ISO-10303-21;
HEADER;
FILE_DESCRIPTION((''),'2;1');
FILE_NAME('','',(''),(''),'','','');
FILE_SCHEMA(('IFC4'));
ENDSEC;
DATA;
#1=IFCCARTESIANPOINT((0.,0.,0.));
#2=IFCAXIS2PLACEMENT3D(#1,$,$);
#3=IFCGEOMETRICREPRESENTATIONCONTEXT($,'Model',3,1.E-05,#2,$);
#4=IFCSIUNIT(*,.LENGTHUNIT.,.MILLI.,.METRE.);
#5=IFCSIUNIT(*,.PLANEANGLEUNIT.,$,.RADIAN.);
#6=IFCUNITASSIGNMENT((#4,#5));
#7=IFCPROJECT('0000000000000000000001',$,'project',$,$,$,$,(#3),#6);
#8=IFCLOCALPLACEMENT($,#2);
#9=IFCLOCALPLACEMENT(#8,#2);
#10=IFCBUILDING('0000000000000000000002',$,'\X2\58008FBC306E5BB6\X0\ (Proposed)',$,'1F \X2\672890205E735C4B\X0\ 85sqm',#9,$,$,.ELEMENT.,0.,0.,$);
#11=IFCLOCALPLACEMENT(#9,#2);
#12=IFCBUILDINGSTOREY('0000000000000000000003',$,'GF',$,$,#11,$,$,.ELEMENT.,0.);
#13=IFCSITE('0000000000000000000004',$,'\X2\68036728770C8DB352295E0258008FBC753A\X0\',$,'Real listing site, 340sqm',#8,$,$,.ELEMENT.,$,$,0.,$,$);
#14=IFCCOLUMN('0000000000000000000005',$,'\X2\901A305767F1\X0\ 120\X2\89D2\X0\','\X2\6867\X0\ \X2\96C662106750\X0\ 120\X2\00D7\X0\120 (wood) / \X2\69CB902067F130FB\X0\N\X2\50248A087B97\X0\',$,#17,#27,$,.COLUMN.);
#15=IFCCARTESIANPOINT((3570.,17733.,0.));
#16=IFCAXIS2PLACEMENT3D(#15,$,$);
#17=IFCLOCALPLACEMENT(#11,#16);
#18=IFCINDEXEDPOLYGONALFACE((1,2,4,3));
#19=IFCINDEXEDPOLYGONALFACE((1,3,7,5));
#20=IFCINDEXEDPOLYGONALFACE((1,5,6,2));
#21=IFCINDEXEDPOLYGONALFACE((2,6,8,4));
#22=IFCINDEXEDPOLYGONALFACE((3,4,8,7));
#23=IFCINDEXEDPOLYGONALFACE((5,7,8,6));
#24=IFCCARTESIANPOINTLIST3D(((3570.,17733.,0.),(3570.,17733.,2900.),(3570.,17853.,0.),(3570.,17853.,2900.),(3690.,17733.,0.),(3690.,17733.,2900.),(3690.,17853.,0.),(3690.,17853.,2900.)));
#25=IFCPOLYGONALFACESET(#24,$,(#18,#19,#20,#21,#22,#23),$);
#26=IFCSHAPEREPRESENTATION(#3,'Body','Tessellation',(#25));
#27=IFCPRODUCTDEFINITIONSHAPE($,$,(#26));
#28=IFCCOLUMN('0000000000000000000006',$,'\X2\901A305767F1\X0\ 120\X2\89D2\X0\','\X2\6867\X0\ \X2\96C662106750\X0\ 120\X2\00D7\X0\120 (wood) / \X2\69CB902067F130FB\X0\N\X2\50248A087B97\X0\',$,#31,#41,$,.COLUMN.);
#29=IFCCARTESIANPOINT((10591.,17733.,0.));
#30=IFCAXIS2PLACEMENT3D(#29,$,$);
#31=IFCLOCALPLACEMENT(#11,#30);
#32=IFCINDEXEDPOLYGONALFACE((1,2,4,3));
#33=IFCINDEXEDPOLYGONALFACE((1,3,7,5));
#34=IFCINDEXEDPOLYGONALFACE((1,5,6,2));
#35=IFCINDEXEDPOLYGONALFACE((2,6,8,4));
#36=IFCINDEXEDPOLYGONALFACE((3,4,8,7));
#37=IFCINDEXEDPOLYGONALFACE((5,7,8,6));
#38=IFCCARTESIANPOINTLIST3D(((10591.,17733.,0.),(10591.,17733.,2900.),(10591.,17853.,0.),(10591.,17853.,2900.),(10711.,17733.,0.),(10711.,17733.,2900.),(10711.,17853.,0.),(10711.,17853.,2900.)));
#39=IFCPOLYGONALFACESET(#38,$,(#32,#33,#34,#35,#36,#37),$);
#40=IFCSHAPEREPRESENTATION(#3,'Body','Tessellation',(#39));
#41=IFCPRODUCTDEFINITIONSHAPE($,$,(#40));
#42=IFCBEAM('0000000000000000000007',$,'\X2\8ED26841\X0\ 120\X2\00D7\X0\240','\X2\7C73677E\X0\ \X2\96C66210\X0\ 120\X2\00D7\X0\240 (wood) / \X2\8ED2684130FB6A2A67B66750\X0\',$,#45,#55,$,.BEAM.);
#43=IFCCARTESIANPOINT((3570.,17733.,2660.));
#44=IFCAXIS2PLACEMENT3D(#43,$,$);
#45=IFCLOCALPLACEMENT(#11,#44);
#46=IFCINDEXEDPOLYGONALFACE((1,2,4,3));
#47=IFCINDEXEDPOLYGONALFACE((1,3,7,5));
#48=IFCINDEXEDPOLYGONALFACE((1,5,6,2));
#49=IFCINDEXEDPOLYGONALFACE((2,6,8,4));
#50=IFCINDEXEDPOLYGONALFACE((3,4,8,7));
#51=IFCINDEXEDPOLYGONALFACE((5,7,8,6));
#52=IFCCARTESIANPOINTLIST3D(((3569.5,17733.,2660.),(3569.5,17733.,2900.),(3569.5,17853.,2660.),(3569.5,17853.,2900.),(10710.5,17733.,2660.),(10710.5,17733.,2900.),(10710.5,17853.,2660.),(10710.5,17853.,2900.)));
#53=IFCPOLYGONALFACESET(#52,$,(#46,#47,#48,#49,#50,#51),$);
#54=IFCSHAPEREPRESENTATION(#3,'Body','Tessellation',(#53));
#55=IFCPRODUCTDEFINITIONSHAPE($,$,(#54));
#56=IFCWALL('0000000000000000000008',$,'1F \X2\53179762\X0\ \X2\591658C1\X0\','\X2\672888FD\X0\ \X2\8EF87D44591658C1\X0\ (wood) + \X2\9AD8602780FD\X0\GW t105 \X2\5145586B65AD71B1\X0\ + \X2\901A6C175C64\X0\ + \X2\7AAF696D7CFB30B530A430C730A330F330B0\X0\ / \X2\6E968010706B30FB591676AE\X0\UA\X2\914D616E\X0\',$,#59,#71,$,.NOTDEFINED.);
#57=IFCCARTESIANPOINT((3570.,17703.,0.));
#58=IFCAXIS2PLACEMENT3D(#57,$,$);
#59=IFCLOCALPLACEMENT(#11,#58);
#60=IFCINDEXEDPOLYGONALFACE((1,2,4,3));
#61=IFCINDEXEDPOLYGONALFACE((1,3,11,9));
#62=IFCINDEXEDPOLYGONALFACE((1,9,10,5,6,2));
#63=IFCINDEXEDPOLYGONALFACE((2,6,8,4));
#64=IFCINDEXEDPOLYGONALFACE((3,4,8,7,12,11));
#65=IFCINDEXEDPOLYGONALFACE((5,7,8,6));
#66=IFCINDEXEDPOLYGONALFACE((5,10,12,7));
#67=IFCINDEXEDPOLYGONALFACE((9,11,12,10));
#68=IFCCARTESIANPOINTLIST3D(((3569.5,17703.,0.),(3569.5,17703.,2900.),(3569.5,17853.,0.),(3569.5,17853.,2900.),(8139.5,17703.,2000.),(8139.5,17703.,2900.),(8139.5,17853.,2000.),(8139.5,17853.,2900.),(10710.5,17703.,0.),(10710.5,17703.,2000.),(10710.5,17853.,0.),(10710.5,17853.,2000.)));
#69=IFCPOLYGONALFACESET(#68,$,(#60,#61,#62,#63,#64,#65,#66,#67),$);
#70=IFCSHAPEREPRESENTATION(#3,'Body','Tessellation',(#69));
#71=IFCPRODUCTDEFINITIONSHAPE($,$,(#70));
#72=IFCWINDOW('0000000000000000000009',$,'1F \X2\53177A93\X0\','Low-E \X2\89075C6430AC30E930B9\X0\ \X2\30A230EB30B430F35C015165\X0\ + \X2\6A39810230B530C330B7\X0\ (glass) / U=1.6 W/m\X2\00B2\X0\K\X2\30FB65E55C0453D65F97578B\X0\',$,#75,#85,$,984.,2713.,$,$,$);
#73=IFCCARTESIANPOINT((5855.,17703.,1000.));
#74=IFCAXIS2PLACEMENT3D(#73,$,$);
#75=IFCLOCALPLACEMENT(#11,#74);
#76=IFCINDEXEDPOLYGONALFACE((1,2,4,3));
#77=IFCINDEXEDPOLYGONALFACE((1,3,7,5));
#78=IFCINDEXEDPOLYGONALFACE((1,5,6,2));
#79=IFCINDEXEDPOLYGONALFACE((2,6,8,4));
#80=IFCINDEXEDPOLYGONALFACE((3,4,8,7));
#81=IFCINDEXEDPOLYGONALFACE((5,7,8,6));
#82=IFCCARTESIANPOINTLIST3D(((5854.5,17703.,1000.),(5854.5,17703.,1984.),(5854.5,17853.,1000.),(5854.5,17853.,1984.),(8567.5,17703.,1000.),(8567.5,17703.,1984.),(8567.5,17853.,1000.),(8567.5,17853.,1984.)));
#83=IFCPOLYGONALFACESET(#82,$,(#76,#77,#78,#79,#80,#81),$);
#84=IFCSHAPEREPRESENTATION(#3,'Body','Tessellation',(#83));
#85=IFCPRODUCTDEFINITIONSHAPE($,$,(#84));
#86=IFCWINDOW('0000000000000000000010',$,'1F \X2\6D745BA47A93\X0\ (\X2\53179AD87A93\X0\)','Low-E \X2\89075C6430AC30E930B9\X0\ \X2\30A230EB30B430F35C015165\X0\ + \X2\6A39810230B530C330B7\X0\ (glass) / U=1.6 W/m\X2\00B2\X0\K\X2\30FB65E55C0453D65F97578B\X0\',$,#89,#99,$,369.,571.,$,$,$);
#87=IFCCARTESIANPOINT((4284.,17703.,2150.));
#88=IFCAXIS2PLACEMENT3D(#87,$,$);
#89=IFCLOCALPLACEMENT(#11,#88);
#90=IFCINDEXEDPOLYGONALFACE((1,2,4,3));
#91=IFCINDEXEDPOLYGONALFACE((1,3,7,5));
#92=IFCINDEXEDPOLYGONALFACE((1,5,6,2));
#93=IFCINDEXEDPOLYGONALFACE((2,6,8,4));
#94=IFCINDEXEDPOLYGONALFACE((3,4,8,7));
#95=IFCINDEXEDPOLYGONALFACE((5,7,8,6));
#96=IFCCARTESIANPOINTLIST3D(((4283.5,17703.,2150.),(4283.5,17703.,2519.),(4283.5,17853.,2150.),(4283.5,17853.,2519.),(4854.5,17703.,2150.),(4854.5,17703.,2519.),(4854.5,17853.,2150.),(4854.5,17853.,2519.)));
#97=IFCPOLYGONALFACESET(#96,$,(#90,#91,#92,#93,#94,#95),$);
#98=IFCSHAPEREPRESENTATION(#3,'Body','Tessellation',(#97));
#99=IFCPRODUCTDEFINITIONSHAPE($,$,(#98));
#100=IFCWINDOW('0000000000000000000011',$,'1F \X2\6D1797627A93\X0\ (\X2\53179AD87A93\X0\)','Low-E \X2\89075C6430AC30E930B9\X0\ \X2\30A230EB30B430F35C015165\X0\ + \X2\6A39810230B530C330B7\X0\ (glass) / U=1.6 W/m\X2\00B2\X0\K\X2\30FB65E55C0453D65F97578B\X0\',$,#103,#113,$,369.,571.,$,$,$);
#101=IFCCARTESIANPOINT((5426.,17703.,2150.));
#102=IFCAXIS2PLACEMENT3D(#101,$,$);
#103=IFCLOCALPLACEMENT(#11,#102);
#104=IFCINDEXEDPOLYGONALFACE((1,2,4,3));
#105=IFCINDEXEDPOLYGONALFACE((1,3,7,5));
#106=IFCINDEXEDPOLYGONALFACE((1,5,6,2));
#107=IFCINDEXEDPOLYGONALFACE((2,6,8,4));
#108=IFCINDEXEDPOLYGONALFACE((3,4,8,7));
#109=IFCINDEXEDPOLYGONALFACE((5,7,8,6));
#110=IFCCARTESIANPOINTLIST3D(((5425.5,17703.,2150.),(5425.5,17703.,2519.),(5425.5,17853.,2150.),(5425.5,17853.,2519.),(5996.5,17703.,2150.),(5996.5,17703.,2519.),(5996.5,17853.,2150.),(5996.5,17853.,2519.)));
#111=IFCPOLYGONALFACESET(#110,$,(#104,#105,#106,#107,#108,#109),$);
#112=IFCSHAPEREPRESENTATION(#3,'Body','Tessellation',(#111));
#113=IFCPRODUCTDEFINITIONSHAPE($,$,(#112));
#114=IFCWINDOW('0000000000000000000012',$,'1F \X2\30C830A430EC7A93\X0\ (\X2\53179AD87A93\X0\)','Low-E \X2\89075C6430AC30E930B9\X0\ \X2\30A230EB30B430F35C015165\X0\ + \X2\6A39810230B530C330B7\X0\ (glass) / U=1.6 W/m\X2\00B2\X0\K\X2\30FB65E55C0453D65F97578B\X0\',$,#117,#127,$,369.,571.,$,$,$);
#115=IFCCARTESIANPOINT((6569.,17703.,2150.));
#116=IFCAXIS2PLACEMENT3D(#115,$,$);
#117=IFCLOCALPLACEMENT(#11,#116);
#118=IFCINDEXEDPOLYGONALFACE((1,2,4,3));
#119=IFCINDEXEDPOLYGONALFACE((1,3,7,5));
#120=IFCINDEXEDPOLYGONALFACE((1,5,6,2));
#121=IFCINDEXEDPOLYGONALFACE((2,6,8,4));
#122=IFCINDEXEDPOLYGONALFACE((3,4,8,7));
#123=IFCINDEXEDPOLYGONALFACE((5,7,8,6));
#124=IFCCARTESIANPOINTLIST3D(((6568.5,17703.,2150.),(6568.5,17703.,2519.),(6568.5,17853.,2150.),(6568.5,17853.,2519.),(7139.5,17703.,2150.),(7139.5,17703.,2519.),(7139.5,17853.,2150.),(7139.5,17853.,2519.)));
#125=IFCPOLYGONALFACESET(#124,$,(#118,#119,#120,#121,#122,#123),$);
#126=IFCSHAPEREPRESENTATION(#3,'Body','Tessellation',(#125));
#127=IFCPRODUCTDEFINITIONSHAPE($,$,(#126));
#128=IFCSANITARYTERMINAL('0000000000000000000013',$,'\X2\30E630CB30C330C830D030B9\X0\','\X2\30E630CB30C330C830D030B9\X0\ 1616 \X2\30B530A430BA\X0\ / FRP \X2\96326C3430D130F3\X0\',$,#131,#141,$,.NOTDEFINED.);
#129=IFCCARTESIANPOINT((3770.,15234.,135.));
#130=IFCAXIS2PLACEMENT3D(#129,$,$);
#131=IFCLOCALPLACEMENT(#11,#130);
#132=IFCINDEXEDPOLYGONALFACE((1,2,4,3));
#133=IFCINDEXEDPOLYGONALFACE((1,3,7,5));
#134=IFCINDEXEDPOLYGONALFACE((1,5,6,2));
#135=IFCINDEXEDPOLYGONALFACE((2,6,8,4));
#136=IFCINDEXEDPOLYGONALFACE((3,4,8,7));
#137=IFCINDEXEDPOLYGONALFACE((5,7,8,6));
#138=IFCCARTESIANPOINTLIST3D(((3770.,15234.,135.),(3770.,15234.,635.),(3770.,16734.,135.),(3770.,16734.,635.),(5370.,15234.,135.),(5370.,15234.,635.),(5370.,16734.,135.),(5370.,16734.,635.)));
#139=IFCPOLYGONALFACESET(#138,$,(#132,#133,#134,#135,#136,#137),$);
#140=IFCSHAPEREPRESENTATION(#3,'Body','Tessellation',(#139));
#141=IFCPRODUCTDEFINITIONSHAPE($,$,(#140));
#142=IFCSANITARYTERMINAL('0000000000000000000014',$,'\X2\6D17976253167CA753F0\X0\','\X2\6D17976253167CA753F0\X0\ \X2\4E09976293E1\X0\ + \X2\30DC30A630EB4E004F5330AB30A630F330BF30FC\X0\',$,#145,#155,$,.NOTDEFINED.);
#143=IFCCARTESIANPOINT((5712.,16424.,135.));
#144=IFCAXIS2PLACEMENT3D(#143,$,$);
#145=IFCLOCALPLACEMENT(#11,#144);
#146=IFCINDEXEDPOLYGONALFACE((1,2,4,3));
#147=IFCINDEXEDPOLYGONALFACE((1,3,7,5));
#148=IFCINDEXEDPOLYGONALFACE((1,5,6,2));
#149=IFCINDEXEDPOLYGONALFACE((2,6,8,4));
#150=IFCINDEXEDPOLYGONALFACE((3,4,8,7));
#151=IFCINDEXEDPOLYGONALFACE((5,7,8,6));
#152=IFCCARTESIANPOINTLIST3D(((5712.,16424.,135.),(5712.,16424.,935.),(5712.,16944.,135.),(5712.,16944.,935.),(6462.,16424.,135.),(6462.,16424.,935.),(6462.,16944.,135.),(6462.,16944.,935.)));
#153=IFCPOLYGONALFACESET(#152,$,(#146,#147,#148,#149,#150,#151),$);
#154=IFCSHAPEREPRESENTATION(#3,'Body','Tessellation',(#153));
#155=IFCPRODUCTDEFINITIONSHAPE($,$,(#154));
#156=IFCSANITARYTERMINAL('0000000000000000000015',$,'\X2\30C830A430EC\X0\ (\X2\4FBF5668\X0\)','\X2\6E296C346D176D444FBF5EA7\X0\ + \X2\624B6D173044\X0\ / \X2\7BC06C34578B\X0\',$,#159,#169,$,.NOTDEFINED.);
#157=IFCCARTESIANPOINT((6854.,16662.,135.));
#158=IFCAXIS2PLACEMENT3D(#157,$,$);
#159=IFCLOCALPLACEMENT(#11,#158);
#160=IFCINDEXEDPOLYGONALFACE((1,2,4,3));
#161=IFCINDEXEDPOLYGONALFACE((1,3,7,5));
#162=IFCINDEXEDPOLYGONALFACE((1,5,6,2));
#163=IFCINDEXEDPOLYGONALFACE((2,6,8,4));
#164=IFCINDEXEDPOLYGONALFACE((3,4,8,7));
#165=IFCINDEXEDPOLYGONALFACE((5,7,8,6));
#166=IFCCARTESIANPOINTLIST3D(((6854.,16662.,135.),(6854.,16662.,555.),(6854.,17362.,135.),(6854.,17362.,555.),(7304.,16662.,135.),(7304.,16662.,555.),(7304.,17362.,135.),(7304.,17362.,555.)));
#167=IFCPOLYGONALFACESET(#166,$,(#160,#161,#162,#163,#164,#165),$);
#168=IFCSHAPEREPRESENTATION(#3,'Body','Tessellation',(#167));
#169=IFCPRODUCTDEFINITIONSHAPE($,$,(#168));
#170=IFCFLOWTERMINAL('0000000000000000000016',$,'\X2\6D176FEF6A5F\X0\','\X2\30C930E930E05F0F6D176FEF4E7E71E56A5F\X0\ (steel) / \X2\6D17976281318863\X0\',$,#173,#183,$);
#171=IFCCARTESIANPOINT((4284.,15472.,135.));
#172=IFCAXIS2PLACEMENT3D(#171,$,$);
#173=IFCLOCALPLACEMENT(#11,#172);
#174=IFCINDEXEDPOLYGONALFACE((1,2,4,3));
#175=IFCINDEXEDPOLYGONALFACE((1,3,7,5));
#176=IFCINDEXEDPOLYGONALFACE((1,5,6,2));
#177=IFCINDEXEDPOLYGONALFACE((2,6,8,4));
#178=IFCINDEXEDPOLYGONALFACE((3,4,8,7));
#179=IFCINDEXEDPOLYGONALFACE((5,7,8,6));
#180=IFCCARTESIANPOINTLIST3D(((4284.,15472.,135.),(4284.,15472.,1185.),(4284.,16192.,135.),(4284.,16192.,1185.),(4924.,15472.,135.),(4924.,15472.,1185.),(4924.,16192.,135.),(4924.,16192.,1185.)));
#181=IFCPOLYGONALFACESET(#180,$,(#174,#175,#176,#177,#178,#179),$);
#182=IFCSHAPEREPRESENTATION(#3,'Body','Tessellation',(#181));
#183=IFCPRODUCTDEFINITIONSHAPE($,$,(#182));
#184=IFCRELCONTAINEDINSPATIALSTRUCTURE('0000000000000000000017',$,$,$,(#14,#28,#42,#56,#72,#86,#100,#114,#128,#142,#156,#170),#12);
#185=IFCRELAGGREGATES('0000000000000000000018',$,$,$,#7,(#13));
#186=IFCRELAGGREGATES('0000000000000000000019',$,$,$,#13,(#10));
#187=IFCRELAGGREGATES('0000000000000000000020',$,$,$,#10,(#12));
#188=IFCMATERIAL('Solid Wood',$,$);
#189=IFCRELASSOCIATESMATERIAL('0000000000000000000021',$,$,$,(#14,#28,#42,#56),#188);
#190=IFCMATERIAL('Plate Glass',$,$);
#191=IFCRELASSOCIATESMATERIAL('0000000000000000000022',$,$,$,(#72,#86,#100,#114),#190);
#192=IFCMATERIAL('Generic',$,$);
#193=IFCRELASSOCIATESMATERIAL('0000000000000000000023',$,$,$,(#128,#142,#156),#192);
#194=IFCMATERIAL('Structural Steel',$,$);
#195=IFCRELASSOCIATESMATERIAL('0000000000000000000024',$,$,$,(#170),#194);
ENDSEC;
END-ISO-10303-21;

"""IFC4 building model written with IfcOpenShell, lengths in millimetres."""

from ifc_helpers import new_model, si_unit, frame, frame_2d, origin, place, context, project, spatial, rectangle, extrude, material, element, fill, save


model = new_model("IFC4")

# Units and contexts
model_context = context("Model", 3, precision=1e-05, world=origin())
ifc_project = project(units=[si_unit("LENGTHUNIT", "METRE", prefix="MILLI"), si_unit("PLANEANGLEUNIT", "RADIAN")], contexts=[model_context])

# Site, building, storey
site_placement = place(None, origin())
site = spatial("IfcSite", under=ifc_project, at=site_placement, Name="栃木県足利市堀込町", ObjectType="Real listing site, 340sqm", CompositionType="ELEMENT", RefElevation=0.0)
building_placement = place(site_placement, origin())
building = spatial("IfcBuilding", under=site, at=building_placement, Name="堀込の家 (Proposed)", ObjectType="1F 木造平屋 85sqm", CompositionType="ELEMENT", ElevationOfRefHeight=0.0, ElevationOfTerrain=0.0)
storey_placement = place(building_placement, origin())
storey = spatial("IfcBuildingStorey", under=building, at=storey_placement, Name="GF", CompositionType="ELEMENT", Elevation=0.0)

# Columns
ifc_material_1 = material(Name="Solid Wood")
column_1_placement = place(storey_placement, frame((3570.0, 17733.0, 0.0)))
element("IfcColumn", 1, at=column_1_placement, inside=storey, material=ifc_material_1, Name="通し柱 120角", Description="桧 集成材 120×120 (wood) / 構造柱・N値計算", PredefinedType="COLUMN", context=model_context, shape_type="SweptSolid", body=[
    extrude(rectangle(XDim=120.0, YDim=120.0, at=frame_2d((60.0, 60.0))), frame((3570.0, 17733.0, 0.0)), (0.0, 0.0, 1.0), 2900.0),
])
column_2_placement = place(storey_placement, frame((10591.0, 17733.0, 0.0)))
element("IfcColumn", 2, at=column_2_placement, inside=storey, material=ifc_material_1, Name="通し柱 120角", Description="桧 集成材 120×120 (wood) / 構造柱・N値計算", PredefinedType="COLUMN", context=model_context, shape_type="SweptSolid", body=[
    extrude(rectangle(XDim=120.0, YDim=120.0, at=frame_2d((60.0, 60.0))), frame((10591.0, 17733.0, 0.0)), (0.0, 0.0, 1.0), 2900.0),
])

# Beam
beam_1_placement = place(storey_placement, frame((3570.0, 17733.0, 2660.0)))
element("IfcBeam", 3, at=beam_1_placement, inside=storey, material=ifc_material_1, Name="軒桁 120×240", Description="米松 集成 120×240 (wood) / 軒桁・横架材", PredefinedType="BEAM", context=model_context, shape_type="SweptSolid", body=[
    extrude(rectangle(XDim=7141.0, YDim=120.0, at=frame_2d((3570.0, 60.0))), frame((3570.0, 17733.0, 2660.0)), (0.0, 0.0, 1.0), 240.0),
])

# Wall, openings, windows
wall_placement = place(storey_placement, frame((3570.0, 17703.0, 0.0)))
wall = element("IfcWall", 4, at=wall_placement, inside=storey, material=ifc_material_1, Name="1F 北面 外壁", Description="木製 軸組外壁 (wood) + 高性能GW t105 充填断熱 + 通気層 + 窯業系サイディング / 準耐火・外皮UA配慮", PredefinedType="NOTDEFINED", context=model_context, shape_type="SweptSolid", body=[
    extrude(rectangle(XDim=7141.0, YDim=150.0, at=frame_2d((3570.0, 75.0))), frame((3570.0, 17703.0, 0.0)), (0.0, 0.0, 1.0), 2900.0),
])
opening_1_placement = place(storey_placement, frame((5855.0, 17703.0, 1000.0)))
opening_1 = element("IfcOpeningElement", 5, at=opening_1_placement, cuts=wall, PredefinedType="NOTDEFINED", context=model_context, shape_type="SweptSolid", body=[
    extrude(rectangle(XDim=2713.0, YDim=150.0, at=frame_2d((1356.0, 75.0))), frame((5855.0, 17703.0, 1000.0)), (0.0, 0.0, 1.0), 984.0),
])
opening_2_placement = place(storey_placement, frame((4284.0, 17703.0, 2150.0)))
opening_2 = element("IfcOpeningElement", 6, at=opening_2_placement, cuts=wall, PredefinedType="NOTDEFINED", context=model_context, shape_type="SweptSolid", body=[
    extrude(rectangle(XDim=571.0, YDim=150.0, at=frame_2d((285.0, 75.0))), frame((4284.0, 17703.0, 2150.0)), (0.0, 0.0, 1.0), 369.0),
])
opening_3_placement = place(storey_placement, frame((5426.0, 17703.0, 2150.0)))
opening_3 = element("IfcOpeningElement", 7, at=opening_3_placement, cuts=wall, PredefinedType="NOTDEFINED", context=model_context, shape_type="SweptSolid", body=[
    extrude(rectangle(XDim=571.0, YDim=150.0, at=frame_2d((285.0, 75.0))), frame((5426.0, 17703.0, 2150.0)), (0.0, 0.0, 1.0), 369.0),
])
opening_4_placement = place(storey_placement, frame((6569.0, 17703.0, 2150.0)))
opening_4 = element("IfcOpeningElement", 8, at=opening_4_placement, cuts=wall, PredefinedType="NOTDEFINED", context=model_context, shape_type="SweptSolid", body=[
    extrude(rectangle(XDim=571.0, YDim=150.0, at=frame_2d((285.0, 75.0))), frame((6569.0, 17703.0, 2150.0)), (0.0, 0.0, 1.0), 369.0),
])
ifc_material_2 = material(Name="Plate Glass")
window_1_placement = place(storey_placement, frame((5855.0, 17703.0, 1000.0)))
window_1 = element("IfcWindow", 9, at=window_1_placement, inside=storey, material=ifc_material_2, Name="1F 北窓", Description="Low-E 複層ガラス アルゴン封入 + 樹脂サッシ (glass) / U=1.6 W/m²K・日射取得型", OverallHeight=984.0, OverallWidth=2713.0, context=model_context, shape_type="SweptSolid", body=[
    extrude(rectangle(XDim=2713.0, YDim=150.0, at=frame_2d((1356.0, 75.0))), frame((5855.0, 17703.0, 1000.0)), (0.0, 0.0, 1.0), 984.0),
])
fill(opening_1, window_1)
window_2_placement = place(storey_placement, frame((4284.0, 17703.0, 2150.0)))
window_2 = element("IfcWindow", 10, at=window_2_placement, inside=storey, material=ifc_material_2, Name="1F 浴室窓 (北高窓)", Description="Low-E 複層ガラス アルゴン封入 + 樹脂サッシ (glass) / U=1.6 W/m²K・日射取得型", OverallHeight=369.0, OverallWidth=571.0, context=model_context, shape_type="SweptSolid", body=[
    extrude(rectangle(XDim=571.0, YDim=150.0, at=frame_2d((285.0, 75.0))), frame((4284.0, 17703.0, 2150.0)), (0.0, 0.0, 1.0), 369.0),
])
fill(opening_2, window_2)
window_3_placement = place(storey_placement, frame((5426.0, 17703.0, 2150.0)))
window_3 = element("IfcWindow", 11, at=window_3_placement, inside=storey, material=ifc_material_2, Name="1F 洗面窓 (北高窓)", Description="Low-E 複層ガラス アルゴン封入 + 樹脂サッシ (glass) / U=1.6 W/m²K・日射取得型", OverallHeight=369.0, OverallWidth=571.0, context=model_context, shape_type="SweptSolid", body=[
    extrude(rectangle(XDim=571.0, YDim=150.0, at=frame_2d((285.0, 75.0))), frame((5426.0, 17703.0, 2150.0)), (0.0, 0.0, 1.0), 369.0),
])
fill(opening_3, window_3)
window_4_placement = place(storey_placement, frame((6569.0, 17703.0, 2150.0)))
window_4 = element("IfcWindow", 12, at=window_4_placement, inside=storey, material=ifc_material_2, Name="1F トイレ窓 (北高窓)", Description="Low-E 複層ガラス アルゴン封入 + 樹脂サッシ (glass) / U=1.6 W/m²K・日射取得型", OverallHeight=369.0, OverallWidth=571.0, context=model_context, shape_type="SweptSolid", body=[
    extrude(rectangle(XDim=571.0, YDim=150.0, at=frame_2d((285.0, 75.0))), frame((6569.0, 17703.0, 2150.0)), (0.0, 0.0, 1.0), 369.0),
])
fill(opening_4, window_4)

# Sanitary terminals
ifc_material_3 = material(Name="Generic")
sanitary_terminal_1_placement = place(storey_placement, frame((3770.0, 15234.0, 135.0)))
element("IfcSanitaryTerminal", 13, at=sanitary_terminal_1_placement, inside=storey, material=ifc_material_3, Name="ユニットバス", Description="ユニットバス 1616 サイズ / FRP 防水パン", PredefinedType="NOTDEFINED", context=model_context, shape_type="SweptSolid", body=[
    extrude(rectangle(XDim=1600.0, YDim=1500.0, at=frame_2d((800.0, 750.0))), frame((3770.0, 15234.0, 135.0)), (0.0, 0.0, 1.0), 500.0),
])
sanitary_terminal_2_placement = place(storey_placement, frame((5712.0, 16424.0, 135.0)))
element("IfcSanitaryTerminal", 14, at=sanitary_terminal_2_placement, inside=storey, material=ifc_material_3, Name="洗面化粧台", Description="洗面化粧台 三面鏡 + ボウル一体カウンター", PredefinedType="NOTDEFINED", context=model_context, shape_type="SweptSolid", body=[
    extrude(rectangle(XDim=750.0, YDim=520.0, at=frame_2d((375.0, 260.0))), frame((5712.0, 16424.0, 135.0)), (0.0, 0.0, 1.0), 800.0),
])
sanitary_terminal_3_placement = place(storey_placement, frame((6854.0, 16662.0, 135.0)))
element("IfcSanitaryTerminal", 15, at=sanitary_terminal_3_placement, inside=storey, material=ifc_material_3, Name="トイレ (便器)", Description="温水洗浄便座 + 手洗い / 節水型", PredefinedType="NOTDEFINED", context=model_context, shape_type="SweptSolid", body=[
    extrude(rectangle(XDim=450.0, YDim=700.0, at=frame_2d((225.0, 350.0))), frame((6854.0, 16662.0, 135.0)), (0.0, 0.0, 1.0), 420.0),
])

# Flow terminal
ifc_material_4 = material(Name="Structural Steel")
flow_terminal_placement = place(storey_placement, frame((4284.0, 15472.0, 135.0)))
element("IfcFlowTerminal", 16, at=flow_terminal_placement, inside=storey, material=ifc_material_4, Name="洗濯機", Description="ドラム式洗濯乾燥機 (steel) / 洗面脱衣", context=model_context, shape_type="SweptSolid", body=[
    extrude(rectangle(XDim=640.0, YDim=720.0, at=frame_2d((320.0, 360.0))), frame((4284.0, 15472.0, 135.0)), (0.0, 0.0, 1.0), 1050.0),
])

save(model, "model.ifc")
